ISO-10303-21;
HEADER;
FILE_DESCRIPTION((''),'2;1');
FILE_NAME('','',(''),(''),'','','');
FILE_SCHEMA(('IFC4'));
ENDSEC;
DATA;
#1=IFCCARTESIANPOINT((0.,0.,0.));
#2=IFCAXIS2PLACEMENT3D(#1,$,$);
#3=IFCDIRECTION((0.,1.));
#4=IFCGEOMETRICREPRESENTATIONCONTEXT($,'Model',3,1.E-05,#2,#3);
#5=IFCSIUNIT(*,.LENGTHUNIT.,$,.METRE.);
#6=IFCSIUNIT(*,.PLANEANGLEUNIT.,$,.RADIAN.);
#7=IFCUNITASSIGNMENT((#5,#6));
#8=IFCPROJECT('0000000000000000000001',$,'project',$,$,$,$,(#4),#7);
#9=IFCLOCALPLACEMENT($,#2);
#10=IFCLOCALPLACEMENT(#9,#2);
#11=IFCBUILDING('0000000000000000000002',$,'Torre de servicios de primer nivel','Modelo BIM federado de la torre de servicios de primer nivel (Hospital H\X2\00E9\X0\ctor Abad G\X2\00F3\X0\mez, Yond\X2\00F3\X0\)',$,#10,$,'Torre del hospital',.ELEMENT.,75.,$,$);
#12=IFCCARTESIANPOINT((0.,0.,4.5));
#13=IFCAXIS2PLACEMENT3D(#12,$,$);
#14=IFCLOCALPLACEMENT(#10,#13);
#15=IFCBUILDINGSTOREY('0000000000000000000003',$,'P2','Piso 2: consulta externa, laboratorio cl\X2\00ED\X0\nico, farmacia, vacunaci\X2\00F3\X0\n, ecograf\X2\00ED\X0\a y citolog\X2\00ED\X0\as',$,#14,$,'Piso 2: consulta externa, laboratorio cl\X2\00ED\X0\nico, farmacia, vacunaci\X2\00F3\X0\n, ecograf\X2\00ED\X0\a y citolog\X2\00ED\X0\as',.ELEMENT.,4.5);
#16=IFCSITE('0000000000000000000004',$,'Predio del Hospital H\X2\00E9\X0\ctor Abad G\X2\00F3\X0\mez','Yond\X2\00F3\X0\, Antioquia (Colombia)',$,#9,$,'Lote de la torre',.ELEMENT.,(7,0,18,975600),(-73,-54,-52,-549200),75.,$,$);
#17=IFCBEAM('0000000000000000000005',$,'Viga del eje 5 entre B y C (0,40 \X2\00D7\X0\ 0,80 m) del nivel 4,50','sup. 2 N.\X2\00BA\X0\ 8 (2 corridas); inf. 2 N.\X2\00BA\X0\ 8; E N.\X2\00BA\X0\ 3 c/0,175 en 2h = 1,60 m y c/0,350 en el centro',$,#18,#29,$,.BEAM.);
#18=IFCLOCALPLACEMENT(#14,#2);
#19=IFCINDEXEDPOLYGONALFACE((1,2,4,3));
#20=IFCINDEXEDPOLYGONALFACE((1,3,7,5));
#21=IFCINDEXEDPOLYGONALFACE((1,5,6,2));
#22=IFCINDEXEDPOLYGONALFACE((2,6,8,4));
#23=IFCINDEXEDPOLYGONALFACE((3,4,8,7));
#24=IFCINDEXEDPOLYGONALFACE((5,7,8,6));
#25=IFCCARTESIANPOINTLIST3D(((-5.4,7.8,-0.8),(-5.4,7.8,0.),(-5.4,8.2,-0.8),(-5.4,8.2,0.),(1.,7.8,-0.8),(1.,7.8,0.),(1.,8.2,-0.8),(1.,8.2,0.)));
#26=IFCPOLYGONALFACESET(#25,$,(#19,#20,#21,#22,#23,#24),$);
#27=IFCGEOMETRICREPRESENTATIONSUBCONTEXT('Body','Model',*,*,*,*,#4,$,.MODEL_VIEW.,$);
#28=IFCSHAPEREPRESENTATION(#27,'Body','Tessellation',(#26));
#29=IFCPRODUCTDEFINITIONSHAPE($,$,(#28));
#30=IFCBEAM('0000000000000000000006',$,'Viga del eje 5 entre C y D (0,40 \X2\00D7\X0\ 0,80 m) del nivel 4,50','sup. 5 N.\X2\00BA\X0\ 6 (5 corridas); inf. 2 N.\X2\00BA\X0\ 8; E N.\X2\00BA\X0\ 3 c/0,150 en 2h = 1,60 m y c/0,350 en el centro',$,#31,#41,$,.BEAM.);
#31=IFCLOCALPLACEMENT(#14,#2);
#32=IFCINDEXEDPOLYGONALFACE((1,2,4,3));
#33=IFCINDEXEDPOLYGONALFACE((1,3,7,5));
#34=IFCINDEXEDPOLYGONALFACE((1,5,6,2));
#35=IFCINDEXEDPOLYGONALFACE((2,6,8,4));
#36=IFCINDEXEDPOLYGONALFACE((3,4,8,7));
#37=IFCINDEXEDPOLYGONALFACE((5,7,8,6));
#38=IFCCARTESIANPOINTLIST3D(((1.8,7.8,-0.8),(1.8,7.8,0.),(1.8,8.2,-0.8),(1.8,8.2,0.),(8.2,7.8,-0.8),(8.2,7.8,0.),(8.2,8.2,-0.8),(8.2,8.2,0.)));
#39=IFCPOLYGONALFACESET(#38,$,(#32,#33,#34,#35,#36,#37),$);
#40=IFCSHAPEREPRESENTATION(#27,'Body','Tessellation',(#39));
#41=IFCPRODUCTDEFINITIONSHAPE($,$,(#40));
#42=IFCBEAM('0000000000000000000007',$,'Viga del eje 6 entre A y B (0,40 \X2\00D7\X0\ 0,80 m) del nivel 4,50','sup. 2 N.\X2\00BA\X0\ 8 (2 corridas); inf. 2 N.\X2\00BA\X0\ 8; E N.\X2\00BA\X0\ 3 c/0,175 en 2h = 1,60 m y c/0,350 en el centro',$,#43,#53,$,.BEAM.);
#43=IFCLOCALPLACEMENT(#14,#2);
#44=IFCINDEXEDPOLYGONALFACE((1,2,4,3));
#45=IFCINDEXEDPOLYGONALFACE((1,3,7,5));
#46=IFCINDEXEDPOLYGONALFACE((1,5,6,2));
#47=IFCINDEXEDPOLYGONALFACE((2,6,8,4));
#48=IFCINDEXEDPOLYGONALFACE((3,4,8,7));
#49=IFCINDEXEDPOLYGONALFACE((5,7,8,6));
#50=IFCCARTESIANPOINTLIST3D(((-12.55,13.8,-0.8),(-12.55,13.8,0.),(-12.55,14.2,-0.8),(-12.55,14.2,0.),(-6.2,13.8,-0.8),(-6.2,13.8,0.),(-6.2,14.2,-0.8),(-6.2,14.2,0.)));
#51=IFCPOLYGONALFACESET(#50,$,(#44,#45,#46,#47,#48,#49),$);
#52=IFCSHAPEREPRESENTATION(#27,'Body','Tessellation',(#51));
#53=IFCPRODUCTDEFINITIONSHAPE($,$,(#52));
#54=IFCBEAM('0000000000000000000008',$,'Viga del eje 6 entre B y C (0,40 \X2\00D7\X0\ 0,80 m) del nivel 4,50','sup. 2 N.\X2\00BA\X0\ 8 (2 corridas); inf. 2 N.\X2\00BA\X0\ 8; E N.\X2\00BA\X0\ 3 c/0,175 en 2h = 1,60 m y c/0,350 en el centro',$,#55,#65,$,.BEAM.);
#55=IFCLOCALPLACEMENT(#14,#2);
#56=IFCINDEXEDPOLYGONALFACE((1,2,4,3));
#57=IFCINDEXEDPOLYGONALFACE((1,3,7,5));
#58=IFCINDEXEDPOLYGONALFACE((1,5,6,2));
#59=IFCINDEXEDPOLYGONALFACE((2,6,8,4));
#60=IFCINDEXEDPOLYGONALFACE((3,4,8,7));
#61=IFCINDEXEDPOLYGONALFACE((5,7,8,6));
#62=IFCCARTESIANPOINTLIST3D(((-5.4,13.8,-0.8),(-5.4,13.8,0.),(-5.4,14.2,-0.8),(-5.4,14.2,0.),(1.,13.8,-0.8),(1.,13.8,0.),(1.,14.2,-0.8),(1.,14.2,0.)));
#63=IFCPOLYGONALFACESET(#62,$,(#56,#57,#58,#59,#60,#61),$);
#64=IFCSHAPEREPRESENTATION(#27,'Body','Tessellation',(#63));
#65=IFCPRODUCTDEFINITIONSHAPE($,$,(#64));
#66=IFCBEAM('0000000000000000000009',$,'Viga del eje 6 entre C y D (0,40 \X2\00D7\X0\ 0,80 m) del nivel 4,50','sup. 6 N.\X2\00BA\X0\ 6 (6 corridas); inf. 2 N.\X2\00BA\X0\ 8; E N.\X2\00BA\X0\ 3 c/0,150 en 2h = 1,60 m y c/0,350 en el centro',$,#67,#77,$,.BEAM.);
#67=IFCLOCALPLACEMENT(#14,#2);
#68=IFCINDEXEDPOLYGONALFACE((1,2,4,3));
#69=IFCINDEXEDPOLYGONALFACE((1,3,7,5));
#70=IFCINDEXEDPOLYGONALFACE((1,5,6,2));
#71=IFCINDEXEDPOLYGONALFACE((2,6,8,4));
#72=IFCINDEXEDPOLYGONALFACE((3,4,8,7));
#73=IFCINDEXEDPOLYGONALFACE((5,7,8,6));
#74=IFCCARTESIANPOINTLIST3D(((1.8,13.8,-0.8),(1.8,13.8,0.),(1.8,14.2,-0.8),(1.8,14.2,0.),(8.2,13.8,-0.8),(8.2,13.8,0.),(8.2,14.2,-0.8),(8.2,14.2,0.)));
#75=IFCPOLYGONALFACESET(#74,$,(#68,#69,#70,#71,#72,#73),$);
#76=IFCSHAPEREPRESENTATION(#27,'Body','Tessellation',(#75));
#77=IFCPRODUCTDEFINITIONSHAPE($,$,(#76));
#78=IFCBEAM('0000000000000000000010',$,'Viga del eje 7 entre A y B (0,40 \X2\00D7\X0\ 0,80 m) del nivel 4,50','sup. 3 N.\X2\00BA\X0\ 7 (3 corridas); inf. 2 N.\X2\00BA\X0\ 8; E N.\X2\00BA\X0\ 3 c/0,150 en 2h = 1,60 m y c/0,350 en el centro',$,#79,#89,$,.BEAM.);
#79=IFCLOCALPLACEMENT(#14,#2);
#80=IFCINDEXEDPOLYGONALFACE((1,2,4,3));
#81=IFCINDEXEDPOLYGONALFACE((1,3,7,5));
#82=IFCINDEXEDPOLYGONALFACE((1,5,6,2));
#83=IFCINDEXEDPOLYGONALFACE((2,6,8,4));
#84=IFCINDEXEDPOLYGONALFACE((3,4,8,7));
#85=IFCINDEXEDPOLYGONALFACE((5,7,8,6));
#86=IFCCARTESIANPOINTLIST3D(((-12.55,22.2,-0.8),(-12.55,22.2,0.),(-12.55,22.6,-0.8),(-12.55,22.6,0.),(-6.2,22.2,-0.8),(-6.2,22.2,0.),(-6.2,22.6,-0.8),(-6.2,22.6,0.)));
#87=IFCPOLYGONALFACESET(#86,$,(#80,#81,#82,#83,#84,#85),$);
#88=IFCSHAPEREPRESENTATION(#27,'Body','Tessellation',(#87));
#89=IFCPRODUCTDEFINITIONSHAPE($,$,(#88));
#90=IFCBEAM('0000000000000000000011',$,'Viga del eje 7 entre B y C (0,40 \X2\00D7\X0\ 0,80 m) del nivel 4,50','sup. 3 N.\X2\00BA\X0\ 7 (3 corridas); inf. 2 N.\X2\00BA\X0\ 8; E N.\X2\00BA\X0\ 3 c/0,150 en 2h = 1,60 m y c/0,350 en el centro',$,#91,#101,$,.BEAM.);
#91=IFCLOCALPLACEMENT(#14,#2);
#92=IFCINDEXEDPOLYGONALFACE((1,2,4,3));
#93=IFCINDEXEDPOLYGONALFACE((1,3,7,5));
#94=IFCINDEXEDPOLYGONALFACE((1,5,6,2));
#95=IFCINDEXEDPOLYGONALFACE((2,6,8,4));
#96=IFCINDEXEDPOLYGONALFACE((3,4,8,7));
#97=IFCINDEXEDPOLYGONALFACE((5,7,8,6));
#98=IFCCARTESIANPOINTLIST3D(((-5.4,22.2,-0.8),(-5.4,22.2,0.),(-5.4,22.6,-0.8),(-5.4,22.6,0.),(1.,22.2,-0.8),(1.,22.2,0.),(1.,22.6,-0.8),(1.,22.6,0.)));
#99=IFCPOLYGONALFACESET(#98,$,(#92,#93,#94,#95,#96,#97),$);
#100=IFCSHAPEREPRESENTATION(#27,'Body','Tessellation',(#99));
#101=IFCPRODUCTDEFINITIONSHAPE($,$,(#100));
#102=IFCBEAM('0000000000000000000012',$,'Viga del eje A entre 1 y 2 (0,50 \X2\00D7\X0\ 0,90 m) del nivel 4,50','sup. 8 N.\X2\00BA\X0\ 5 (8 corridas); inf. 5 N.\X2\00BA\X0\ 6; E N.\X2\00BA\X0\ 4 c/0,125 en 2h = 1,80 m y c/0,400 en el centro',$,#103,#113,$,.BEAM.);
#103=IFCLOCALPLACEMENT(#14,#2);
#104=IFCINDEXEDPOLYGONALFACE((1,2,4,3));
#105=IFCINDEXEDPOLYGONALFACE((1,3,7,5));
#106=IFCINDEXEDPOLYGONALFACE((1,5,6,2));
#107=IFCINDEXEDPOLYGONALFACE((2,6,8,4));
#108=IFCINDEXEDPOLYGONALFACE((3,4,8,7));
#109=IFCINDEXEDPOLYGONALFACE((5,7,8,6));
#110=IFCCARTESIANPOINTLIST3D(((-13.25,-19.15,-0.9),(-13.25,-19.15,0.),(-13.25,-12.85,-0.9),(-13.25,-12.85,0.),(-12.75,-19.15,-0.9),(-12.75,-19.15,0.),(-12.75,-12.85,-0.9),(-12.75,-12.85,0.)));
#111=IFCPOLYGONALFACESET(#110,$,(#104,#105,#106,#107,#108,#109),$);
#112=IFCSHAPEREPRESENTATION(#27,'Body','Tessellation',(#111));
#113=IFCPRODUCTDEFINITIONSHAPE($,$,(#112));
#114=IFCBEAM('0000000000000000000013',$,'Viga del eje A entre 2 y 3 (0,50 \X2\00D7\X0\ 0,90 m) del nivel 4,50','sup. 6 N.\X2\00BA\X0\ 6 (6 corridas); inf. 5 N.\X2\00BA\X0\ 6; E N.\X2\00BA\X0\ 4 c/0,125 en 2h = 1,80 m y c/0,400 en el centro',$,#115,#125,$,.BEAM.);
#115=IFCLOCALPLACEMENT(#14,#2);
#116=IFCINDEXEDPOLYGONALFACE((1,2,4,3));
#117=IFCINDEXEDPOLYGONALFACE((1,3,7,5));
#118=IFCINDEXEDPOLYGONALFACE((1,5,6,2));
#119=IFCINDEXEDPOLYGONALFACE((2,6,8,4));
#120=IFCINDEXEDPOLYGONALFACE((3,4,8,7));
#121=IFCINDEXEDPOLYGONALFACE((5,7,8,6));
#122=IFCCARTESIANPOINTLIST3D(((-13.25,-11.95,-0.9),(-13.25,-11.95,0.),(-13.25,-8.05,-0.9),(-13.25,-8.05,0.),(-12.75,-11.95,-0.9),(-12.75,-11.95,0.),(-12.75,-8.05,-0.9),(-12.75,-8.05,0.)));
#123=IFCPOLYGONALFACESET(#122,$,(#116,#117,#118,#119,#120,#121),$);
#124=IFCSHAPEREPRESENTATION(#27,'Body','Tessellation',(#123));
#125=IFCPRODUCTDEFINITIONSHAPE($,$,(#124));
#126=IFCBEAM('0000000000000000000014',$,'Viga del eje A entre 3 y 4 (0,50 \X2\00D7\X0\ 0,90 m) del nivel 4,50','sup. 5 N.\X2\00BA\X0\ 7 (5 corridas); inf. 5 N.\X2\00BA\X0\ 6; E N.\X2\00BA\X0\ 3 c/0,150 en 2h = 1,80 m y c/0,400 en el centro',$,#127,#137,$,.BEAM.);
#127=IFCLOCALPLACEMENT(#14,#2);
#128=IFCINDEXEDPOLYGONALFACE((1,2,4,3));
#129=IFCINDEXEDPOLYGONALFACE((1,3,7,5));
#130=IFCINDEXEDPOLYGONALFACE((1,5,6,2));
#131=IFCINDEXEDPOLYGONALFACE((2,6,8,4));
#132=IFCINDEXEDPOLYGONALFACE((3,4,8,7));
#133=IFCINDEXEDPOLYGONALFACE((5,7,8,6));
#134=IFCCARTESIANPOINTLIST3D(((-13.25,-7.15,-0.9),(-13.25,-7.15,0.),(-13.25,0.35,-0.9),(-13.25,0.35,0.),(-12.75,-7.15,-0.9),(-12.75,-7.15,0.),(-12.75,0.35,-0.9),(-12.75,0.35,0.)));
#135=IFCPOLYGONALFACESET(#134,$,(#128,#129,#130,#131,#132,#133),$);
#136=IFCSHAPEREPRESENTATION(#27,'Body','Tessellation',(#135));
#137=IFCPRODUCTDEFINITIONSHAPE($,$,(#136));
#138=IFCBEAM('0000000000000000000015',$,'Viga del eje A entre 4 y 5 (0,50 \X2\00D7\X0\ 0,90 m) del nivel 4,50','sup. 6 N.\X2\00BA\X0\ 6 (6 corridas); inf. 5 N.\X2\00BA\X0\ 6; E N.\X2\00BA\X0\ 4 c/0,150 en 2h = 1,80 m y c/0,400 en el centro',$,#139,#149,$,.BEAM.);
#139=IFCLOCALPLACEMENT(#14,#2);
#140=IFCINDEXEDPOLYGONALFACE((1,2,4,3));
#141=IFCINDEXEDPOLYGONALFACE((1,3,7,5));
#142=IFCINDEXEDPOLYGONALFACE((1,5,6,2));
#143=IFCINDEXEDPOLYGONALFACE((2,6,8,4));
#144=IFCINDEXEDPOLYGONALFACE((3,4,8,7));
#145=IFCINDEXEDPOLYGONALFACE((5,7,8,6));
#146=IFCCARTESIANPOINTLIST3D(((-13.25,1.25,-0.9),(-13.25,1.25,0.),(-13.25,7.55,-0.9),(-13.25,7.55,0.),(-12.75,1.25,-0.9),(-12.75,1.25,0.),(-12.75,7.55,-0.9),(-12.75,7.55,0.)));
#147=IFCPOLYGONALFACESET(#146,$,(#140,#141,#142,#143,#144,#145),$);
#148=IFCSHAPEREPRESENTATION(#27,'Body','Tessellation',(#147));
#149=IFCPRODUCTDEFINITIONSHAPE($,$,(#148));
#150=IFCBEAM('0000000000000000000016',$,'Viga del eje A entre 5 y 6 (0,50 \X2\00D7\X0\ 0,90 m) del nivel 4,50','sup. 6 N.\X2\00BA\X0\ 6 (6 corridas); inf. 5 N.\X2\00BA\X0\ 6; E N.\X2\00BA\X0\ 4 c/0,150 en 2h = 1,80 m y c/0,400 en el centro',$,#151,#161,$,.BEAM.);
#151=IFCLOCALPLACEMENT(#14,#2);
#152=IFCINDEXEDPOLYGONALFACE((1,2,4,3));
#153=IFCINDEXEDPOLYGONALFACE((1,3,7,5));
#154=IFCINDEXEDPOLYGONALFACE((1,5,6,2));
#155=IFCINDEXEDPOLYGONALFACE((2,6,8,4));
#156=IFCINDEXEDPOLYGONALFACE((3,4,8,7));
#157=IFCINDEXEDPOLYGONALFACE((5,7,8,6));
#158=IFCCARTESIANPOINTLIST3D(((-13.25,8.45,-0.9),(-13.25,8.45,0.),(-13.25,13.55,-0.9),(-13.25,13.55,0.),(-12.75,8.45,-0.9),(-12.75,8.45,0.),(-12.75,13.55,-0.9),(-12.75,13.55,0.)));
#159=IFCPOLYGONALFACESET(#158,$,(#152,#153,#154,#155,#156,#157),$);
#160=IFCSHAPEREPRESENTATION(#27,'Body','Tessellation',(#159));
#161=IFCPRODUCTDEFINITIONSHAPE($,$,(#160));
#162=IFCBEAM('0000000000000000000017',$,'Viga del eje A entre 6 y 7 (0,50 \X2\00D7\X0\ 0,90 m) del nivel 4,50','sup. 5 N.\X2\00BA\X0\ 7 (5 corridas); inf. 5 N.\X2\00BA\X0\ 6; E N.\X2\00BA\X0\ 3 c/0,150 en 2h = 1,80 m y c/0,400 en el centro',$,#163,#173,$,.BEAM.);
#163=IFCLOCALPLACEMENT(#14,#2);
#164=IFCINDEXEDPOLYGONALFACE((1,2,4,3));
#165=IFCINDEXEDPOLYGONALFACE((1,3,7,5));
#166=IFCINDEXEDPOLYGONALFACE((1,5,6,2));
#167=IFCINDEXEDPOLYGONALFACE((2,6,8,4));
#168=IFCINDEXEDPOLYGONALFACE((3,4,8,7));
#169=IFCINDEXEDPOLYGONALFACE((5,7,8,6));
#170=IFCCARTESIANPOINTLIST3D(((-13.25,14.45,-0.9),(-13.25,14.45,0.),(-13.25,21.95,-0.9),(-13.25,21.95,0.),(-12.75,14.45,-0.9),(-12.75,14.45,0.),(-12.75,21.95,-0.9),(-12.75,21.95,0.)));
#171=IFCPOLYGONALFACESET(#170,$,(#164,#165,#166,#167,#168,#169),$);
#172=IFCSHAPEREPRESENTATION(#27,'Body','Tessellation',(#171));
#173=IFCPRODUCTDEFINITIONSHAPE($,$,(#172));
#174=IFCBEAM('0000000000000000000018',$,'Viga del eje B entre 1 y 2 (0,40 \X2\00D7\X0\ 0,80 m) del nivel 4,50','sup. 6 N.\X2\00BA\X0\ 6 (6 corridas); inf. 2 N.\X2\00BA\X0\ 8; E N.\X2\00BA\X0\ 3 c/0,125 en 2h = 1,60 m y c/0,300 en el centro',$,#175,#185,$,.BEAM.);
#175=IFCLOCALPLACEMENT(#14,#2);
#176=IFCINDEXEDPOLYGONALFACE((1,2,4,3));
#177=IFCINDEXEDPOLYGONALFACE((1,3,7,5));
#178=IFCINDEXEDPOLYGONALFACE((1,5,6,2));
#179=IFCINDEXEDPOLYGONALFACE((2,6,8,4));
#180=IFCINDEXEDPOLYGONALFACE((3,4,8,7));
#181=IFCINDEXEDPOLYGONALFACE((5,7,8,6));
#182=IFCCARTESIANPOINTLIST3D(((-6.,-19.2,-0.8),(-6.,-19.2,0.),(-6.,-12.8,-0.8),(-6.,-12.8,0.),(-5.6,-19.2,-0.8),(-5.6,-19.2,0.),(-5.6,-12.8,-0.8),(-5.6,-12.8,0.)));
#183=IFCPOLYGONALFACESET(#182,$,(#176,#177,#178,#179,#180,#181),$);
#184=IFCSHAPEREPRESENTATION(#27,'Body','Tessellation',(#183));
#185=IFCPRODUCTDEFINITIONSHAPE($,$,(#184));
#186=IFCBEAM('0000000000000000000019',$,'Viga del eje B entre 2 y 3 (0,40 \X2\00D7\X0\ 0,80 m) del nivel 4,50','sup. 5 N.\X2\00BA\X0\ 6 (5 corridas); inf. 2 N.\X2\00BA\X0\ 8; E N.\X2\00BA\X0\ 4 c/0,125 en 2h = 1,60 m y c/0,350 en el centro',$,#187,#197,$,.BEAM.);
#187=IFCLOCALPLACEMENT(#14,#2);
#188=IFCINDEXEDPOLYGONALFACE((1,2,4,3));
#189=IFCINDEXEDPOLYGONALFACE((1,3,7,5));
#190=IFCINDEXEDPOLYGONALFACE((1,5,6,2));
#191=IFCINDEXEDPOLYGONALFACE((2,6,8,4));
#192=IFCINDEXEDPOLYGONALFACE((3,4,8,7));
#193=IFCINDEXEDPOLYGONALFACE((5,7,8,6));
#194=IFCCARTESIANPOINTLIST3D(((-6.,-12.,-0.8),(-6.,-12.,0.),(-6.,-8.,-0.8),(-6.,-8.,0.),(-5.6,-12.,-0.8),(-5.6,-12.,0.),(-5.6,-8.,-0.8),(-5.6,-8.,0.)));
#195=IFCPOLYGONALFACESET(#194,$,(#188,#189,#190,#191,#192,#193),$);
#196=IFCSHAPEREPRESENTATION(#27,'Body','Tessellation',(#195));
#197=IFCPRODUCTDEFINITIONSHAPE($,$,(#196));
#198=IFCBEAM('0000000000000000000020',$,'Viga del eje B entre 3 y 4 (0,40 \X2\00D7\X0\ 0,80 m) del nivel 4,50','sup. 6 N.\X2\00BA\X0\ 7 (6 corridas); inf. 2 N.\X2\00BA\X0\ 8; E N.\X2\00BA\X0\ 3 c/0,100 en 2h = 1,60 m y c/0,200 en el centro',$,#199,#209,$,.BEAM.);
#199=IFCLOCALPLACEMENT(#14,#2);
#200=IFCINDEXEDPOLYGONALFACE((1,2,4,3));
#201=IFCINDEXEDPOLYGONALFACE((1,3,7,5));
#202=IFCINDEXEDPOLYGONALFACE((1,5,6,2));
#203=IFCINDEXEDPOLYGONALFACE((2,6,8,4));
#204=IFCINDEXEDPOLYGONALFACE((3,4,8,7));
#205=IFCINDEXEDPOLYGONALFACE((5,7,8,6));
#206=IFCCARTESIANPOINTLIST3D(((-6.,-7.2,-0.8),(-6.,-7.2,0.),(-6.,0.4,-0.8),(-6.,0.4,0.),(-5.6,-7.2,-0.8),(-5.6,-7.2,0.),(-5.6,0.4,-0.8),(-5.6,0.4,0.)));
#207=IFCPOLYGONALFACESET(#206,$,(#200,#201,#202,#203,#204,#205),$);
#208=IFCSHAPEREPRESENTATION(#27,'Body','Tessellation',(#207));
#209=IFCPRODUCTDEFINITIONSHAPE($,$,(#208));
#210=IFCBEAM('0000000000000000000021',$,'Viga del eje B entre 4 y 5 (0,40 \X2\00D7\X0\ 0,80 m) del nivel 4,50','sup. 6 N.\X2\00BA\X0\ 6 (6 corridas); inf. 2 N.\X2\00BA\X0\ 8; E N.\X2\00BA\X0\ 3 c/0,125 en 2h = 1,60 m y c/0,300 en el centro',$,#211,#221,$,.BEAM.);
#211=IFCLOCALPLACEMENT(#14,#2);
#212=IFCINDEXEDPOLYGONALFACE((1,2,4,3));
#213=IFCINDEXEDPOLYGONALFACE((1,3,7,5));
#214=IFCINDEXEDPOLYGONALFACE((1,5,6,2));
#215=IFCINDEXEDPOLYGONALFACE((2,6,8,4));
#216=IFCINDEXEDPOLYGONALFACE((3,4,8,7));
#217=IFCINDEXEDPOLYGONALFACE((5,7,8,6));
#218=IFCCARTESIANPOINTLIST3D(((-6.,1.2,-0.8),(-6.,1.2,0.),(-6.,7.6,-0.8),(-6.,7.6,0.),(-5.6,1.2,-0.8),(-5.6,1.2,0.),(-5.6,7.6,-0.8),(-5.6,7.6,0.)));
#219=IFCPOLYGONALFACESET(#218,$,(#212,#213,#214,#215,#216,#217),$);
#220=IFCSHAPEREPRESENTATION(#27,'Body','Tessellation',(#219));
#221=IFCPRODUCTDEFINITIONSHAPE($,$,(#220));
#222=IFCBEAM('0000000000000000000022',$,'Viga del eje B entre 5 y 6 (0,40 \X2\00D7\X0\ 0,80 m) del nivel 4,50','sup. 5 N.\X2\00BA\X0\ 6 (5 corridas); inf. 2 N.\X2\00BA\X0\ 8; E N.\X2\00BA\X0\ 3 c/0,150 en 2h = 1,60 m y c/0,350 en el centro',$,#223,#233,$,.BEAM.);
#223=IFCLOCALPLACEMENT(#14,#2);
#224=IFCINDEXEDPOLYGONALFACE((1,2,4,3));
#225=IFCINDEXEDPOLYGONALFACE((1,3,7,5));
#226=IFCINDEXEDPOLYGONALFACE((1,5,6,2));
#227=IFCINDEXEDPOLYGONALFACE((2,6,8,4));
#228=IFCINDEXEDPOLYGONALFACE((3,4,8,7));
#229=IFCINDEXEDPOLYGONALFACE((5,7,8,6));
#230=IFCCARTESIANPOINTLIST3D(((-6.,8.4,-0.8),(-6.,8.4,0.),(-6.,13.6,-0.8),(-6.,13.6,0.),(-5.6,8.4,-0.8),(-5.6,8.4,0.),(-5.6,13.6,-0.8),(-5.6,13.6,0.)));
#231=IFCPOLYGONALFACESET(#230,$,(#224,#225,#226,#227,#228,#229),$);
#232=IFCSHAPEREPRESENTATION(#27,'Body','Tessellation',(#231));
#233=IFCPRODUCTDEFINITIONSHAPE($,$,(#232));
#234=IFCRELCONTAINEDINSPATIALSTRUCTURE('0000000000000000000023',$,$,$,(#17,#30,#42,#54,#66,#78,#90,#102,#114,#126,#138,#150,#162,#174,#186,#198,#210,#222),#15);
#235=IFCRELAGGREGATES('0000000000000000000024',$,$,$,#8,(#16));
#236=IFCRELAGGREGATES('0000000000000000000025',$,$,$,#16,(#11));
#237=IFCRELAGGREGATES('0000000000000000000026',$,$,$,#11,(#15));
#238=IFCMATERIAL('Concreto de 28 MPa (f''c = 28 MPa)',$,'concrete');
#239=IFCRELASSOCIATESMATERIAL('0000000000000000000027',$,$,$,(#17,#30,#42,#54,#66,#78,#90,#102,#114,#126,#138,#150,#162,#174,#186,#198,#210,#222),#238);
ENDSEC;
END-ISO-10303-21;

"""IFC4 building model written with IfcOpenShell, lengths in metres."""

from ifc_helpers import new_model, si_unit, direction, frame, origin, place, context, subcontext, project, spatial, rectangle, extrude, material, element, save


model = new_model("IFC4")

# Units and contexts
model_context = context("Model", 3, precision=1e-05, world=origin(), true_north=direction((0.0, 1.0)))
body_context = subcontext(model_context, "Body", "Model", "MODEL_VIEW")
ifc_project = project(units=[si_unit("LENGTHUNIT", "METRE"), si_unit("PLANEANGLEUNIT", "RADIAN")], contexts=[model_context])

# Site, building, storey
site_placement = place(None, origin())
site = spatial("IfcSite", under=ifc_project, at=site_placement, Name="Predio del Hospital Héctor Abad Gómez", Description="Yondó, Antioquia (Colombia)", LongName="Lote de la torre", CompositionType="ELEMENT", RefLatitude=(7, 0, 18, 975600), RefLongitude=(-73, -54, -52, -549200), RefElevation=75.0)
building_placement = place(site_placement, origin())
building = spatial("IfcBuilding", under=site, at=building_placement, Name="Torre de servicios de primer nivel", Description="Modelo BIM federado de la torre de servicios de primer nivel (Hospital Héctor Abad Gómez, Yondó)", LongName="Torre del hospital", CompositionType="ELEMENT", ElevationOfRefHeight=75.0)
placement = place(building_placement, frame((0.0, 0.0, 4.5)))
storey = spatial("IfcBuildingStorey", under=building, at=placement, Name="P2", Description="Piso 2: consulta externa, laboratorio clínico, farmacia, vacunación, ecografía y citologías", LongName="Piso 2: consulta externa, laboratorio clínico, farmacia, vacunación, ecografía y citologías", CompositionType="ELEMENT", Elevation=4.5)

# Beams
ifc_material = material(Name="Concreto de 28 MPa (f'c = 28 MPa)", Category="concrete")
element("IfcBeam", 1, at=placement, inside=storey, material=ifc_material, Name="Viga del eje 5 entre B y C (0,40 × 0,80 m) del nivel 4,50", Description="sup. 2 N.º 8 (2 corridas); inf. 2 N.º 8; E N.º 3 c/0,175 en 2h = 1,60 m y c/0,350 en el centro", PredefinedType="BEAM", context=body_context, shape_type="SweptSolid", body=[
    extrude(rectangle(XDim=6.4, YDim=0.4), frame((-2.2, 8.0, -0.8)), (0.0, 0.0, 1.0), 0.8),
])
element("IfcBeam", 2, at=placement, inside=storey, material=ifc_material, Name="Viga del eje 5 entre C y D (0,40 × 0,80 m) del nivel 4,50", Description="sup. 5 N.º 6 (5 corridas); inf. 2 N.º 8; E N.º 3 c/0,150 en 2h = 1,60 m y c/0,350 en el centro", PredefinedType="BEAM", context=body_context, shape_type="SweptSolid", body=[
    extrude(rectangle(XDim=6.4, YDim=0.4), frame((5.0, 8.0, -0.8)), (0.0, 0.0, 1.0), 0.8),
])
element("IfcBeam", 3, at=placement, inside=storey, material=ifc_material, Name="Viga del eje 6 entre A y B (0,40 × 0,80 m) del nivel 4,50", Description="sup. 2 N.º 8 (2 corridas); inf. 2 N.º 8; E N.º 3 c/0,175 en 2h = 1,60 m y c/0,350 en el centro", PredefinedType="BEAM", context=body_context, shape_type="SweptSolid", body=[
    extrude(rectangle(XDim=6.35, YDim=0.4), frame((-9.375, 14.0, -0.8)), (0.0, 0.0, 1.0), 0.8),
])
element("IfcBeam", 4, at=placement, inside=storey, material=ifc_material, Name="Viga del eje 6 entre B y C (0,40 × 0,80 m) del nivel 4,50", Description="sup. 2 N.º 8 (2 corridas); inf. 2 N.º 8; E N.º 3 c/0,175 en 2h = 1,60 m y c/0,350 en el centro", PredefinedType="BEAM", context=body_context, shape_type="SweptSolid", body=[
    extrude(rectangle(XDim=6.4, YDim=0.4), frame((-2.2, 14.0, -0.8)), (0.0, 0.0, 1.0), 0.8),
])
element("IfcBeam", 5, at=placement, inside=storey, material=ifc_material, Name="Viga del eje 6 entre C y D (0,40 × 0,80 m) del nivel 4,50", Description="sup. 6 N.º 6 (6 corridas); inf. 2 N.º 8; E N.º 3 c/0,150 en 2h = 1,60 m y c/0,350 en el centro", PredefinedType="BEAM", context=body_context, shape_type="SweptSolid", body=[
    extrude(rectangle(XDim=6.4, YDim=0.4), frame((5.0, 14.0, -0.8)), (0.0, 0.0, 1.0), 0.8),
])
element("IfcBeam", 6, at=placement, inside=storey, material=ifc_material, Name="Viga del eje 7 entre A y B (0,40 × 0,80 m) del nivel 4,50", Description="sup. 3 N.º 7 (3 corridas); inf. 2 N.º 8; E N.º 3 c/0,150 en 2h = 1,60 m y c/0,350 en el centro", PredefinedType="BEAM", context=body_context, shape_type="SweptSolid", body=[
    extrude(rectangle(XDim=6.35, YDim=0.4), frame((-9.375, 22.4, -0.8)), (0.0, 0.0, 1.0), 0.8),
])
element("IfcBeam", 7, at=placement, inside=storey, material=ifc_material, Name="Viga del eje 7 entre B y C (0,40 × 0,80 m) del nivel 4,50", Description="sup. 3 N.º 7 (3 corridas); inf. 2 N.º 8; E N.º 3 c/0,150 en 2h = 1,60 m y c/0,350 en el centro", PredefinedType="BEAM", context=body_context, shape_type="SweptSolid", body=[
    extrude(rectangle(XDim=6.4, YDim=0.4), frame((-2.2, 22.4, -0.8)), (0.0, 0.0, 1.0), 0.8),
])
element("IfcBeam", 8, at=placement, inside=storey, material=ifc_material, Name="Viga del eje A entre 1 y 2 (0,50 × 0,90 m) del nivel 4,50", Description="sup. 8 N.º 5 (8 corridas); inf. 5 N.º 6; E N.º 4 c/0,125 en 2h = 1,80 m y c/0,400 en el centro", PredefinedType="BEAM", context=body_context, shape_type="SweptSolid", body=[
    extrude(rectangle(XDim=0.5, YDim=6.3), frame((-13.0, -16.0, -0.9)), (0.0, 0.0, 1.0), 0.9),
])
element("IfcBeam", 9, at=placement, inside=storey, material=ifc_material, Name="Viga del eje A entre 2 y 3 (0,50 × 0,90 m) del nivel 4,50", Description="sup. 6 N.º 6 (6 corridas); inf. 5 N.º 6; E N.º 4 c/0,125 en 2h = 1,80 m y c/0,400 en el centro", PredefinedType="BEAM", context=body_context, shape_type="SweptSolid", body=[
    extrude(rectangle(XDim=0.5, YDim=3.9), frame((-13.0, -10.0, -0.9)), (0.0, 0.0, 1.0), 0.9),
])
element("IfcBeam", 10, at=placement, inside=storey, material=ifc_material, Name="Viga del eje A entre 3 y 4 (0,50 × 0,90 m) del nivel 4,50", Description="sup. 5 N.º 7 (5 corridas); inf. 5 N.º 6; E N.º 3 c/0,150 en 2h = 1,80 m y c/0,400 en el centro", PredefinedType="BEAM", context=body_context, shape_type="SweptSolid", body=[
    extrude(rectangle(XDim=0.5, YDim=7.5), frame((-13.0, -3.4, -0.9)), (0.0, 0.0, 1.0), 0.9),
])
element("IfcBeam", 11, at=placement, inside=storey, material=ifc_material, Name="Viga del eje A entre 4 y 5 (0,50 × 0,90 m) del nivel 4,50", Description="sup. 6 N.º 6 (6 corridas); inf. 5 N.º 6; E N.º 4 c/0,150 en 2h = 1,80 m y c/0,400 en el centro", PredefinedType="BEAM", context=body_context, shape_type="SweptSolid", body=[
    extrude(rectangle(XDim=0.5, YDim=6.3), frame((-13.0, 4.4, -0.9)), (0.0, 0.0, 1.0), 0.9),
])
element("IfcBeam", 12, at=placement, inside=storey, material=ifc_material, Name="Viga del eje A entre 5 y 6 (0,50 × 0,90 m) del nivel 4,50", Description="sup. 6 N.º 6 (6 corridas); inf. 5 N.º 6; E N.º 4 c/0,150 en 2h = 1,80 m y c/0,400 en el centro", PredefinedType="BEAM", context=body_context, shape_type="SweptSolid", body=[
    extrude(rectangle(XDim=0.5, YDim=5.1), frame((-13.0, 11.0, -0.9)), (0.0, 0.0, 1.0), 0.9),
])
element("IfcBeam", 13, at=placement, inside=storey, material=ifc_material, Name="Viga del eje A entre 6 y 7 (0,50 × 0,90 m) del nivel 4,50", Description="sup. 5 N.º 7 (5 corridas); inf. 5 N.º 6; E N.º 3 c/0,150 en 2h = 1,80 m y c/0,400 en el centro", PredefinedType="BEAM", context=body_context, shape_type="SweptSolid", body=[
    extrude(rectangle(XDim=0.5, YDim=7.5), frame((-13.0, 18.2, -0.9)), (0.0, 0.0, 1.0), 0.9),
])
element("IfcBeam", 14, at=placement, inside=storey, material=ifc_material, Name="Viga del eje B entre 1 y 2 (0,40 × 0,80 m) del nivel 4,50", Description="sup. 6 N.º 6 (6 corridas); inf. 2 N.º 8; E N.º 3 c/0,125 en 2h = 1,60 m y c/0,300 en el centro", PredefinedType="BEAM", context=body_context, shape_type="SweptSolid", body=[
    extrude(rectangle(XDim=0.4, YDim=6.4), frame((-5.8, -16.0, -0.8)), (0.0, 0.0, 1.0), 0.8),
])
element("IfcBeam", 15, at=placement, inside=storey, material=ifc_material, Name="Viga del eje B entre 2 y 3 (0,40 × 0,80 m) del nivel 4,50", Description="sup. 5 N.º 6 (5 corridas); inf. 2 N.º 8; E N.º 4 c/0,125 en 2h = 1,60 m y c/0,350 en el centro", PredefinedType="BEAM", context=body_context, shape_type="SweptSolid", body=[
    extrude(rectangle(XDim=0.4, YDim=4.0), frame((-5.8, -10.0, -0.8)), (0.0, 0.0, 1.0), 0.8),
])
element("IfcBeam", 16, at=placement, inside=storey, material=ifc_material, Name="Viga del eje B entre 3 y 4 (0,40 × 0,80 m) del nivel 4,50", Description="sup. 6 N.º 7 (6 corridas); inf. 2 N.º 8; E N.º 3 c/0,100 en 2h = 1,60 m y c/0,200 en el centro", PredefinedType="BEAM", context=body_context, shape_type="SweptSolid", body=[
    extrude(rectangle(XDim=0.4, YDim=7.6), frame((-5.8, -3.4, -0.8)), (0.0, 0.0, 1.0), 0.8),
])
element("IfcBeam", 17, at=placement, inside=storey, material=ifc_material, Name="Viga del eje B entre 4 y 5 (0,40 × 0,80 m) del nivel 4,50", Description="sup. 6 N.º 6 (6 corridas); inf. 2 N.º 8; E N.º 3 c/0,125 en 2h = 1,60 m y c/0,300 en el centro", PredefinedType="BEAM", context=body_context, shape_type="SweptSolid", body=[
    extrude(rectangle(XDim=0.4, YDim=6.4), frame((-5.8, 4.4, -0.8)), (0.0, 0.0, 1.0), 0.8),
])
element("IfcBeam", 18, at=placement, inside=storey, material=ifc_material, Name="Viga del eje B entre 5 y 6 (0,40 × 0,80 m) del nivel 4,50", Description="sup. 5 N.º 6 (5 corridas); inf. 2 N.º 8; E N.º 3 c/0,150 en 2h = 1,60 m y c/0,350 en el centro", PredefinedType="BEAM", context=body_context, shape_type="SweptSolid", body=[
    extrude(rectangle(XDim=0.4, YDim=5.2), frame((-5.8, 11.0, -0.8)), (0.0, 0.0, 1.0), 0.8),
])

save(model, "model.ifc")
